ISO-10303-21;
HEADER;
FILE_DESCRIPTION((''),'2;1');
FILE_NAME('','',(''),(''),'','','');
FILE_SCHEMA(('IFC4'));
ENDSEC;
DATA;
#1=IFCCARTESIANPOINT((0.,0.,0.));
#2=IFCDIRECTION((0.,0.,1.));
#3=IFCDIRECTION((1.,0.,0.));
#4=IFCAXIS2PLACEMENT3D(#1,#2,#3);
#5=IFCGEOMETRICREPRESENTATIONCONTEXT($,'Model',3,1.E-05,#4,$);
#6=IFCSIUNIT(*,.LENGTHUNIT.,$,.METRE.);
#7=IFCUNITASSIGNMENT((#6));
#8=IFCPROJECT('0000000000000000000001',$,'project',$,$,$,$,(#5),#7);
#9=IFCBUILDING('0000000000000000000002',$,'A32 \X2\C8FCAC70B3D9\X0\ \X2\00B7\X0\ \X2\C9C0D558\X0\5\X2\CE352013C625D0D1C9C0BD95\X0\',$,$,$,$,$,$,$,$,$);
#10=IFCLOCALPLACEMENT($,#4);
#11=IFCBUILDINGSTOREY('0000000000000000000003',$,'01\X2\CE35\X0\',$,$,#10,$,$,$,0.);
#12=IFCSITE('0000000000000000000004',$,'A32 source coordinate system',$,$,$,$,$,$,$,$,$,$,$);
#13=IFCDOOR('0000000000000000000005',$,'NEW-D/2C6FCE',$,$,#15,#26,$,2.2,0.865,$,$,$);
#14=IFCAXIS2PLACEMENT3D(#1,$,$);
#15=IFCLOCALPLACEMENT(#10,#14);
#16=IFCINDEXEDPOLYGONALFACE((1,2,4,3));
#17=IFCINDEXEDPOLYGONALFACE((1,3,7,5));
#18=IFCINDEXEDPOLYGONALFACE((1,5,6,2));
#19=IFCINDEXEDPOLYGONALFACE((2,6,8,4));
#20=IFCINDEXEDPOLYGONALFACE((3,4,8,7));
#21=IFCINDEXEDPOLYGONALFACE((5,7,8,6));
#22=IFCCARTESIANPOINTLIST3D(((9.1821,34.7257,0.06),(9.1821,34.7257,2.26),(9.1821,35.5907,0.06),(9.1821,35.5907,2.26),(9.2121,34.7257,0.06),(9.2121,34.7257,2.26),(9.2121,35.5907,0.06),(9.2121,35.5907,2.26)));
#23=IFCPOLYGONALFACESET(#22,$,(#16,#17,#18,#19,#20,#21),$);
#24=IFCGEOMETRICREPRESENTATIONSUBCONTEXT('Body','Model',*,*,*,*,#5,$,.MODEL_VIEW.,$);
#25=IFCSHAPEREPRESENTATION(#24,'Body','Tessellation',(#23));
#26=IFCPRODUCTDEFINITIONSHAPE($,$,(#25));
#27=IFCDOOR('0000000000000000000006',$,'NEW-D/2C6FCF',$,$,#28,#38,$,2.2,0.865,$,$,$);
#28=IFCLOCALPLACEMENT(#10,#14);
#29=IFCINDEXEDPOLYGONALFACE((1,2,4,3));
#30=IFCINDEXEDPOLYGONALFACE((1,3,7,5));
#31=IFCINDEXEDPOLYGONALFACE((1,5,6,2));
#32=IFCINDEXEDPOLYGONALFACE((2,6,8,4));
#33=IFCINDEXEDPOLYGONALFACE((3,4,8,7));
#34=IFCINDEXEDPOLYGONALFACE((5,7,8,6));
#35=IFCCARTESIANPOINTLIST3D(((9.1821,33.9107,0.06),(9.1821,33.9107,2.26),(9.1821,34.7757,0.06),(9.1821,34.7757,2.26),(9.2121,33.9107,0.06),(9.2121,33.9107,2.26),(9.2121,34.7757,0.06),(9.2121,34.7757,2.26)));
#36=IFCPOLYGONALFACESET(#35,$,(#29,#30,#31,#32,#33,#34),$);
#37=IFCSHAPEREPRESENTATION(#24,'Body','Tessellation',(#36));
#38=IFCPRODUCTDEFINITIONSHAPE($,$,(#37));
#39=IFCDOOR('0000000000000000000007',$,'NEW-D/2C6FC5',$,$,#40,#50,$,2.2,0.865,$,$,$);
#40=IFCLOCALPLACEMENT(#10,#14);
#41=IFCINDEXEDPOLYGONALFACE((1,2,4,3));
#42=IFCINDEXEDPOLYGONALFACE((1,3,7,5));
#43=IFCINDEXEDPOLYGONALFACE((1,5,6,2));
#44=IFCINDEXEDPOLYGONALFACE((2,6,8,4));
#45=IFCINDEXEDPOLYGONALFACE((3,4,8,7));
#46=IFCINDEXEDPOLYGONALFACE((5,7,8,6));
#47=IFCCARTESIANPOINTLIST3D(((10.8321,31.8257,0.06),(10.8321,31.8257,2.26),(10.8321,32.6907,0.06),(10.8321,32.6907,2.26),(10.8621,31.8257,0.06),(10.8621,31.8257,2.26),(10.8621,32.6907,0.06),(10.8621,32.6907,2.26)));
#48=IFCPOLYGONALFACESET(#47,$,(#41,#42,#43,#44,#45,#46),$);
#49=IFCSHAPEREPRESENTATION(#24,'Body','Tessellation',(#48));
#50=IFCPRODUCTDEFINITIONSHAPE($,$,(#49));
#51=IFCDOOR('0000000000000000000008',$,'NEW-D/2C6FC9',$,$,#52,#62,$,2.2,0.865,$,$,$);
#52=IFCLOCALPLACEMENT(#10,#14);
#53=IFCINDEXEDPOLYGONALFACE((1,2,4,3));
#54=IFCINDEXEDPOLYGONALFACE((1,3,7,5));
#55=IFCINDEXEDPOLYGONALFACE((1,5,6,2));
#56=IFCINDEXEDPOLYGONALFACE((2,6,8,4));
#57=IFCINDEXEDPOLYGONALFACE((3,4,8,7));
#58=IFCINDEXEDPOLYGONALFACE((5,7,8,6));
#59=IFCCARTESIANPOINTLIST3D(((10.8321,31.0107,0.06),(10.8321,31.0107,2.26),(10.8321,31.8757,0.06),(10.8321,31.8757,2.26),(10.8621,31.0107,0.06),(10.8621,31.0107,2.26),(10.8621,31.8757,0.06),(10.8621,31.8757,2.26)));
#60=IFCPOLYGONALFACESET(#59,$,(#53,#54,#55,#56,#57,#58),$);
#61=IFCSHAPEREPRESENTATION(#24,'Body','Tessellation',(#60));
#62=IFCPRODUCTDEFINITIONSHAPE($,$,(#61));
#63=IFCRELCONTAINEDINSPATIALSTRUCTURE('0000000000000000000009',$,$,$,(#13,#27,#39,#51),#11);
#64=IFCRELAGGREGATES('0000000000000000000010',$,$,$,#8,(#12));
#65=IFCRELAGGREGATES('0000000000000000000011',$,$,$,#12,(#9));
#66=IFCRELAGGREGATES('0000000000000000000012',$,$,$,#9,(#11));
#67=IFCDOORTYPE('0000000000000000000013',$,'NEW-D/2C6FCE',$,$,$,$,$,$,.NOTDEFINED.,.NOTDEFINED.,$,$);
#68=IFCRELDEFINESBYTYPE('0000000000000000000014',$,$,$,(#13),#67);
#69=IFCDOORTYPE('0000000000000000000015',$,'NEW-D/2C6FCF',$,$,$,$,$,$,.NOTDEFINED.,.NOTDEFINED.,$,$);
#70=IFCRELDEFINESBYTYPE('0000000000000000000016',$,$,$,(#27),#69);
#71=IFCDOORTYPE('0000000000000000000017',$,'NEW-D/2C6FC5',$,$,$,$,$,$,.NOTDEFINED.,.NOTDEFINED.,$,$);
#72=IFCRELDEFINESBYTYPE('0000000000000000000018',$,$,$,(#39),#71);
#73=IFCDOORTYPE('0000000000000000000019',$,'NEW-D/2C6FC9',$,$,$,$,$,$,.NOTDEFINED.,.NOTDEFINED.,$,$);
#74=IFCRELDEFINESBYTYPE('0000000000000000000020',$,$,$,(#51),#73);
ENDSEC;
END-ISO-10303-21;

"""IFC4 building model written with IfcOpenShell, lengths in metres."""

from ifc_helpers import new_model, si_unit, frame, origin, origin_with_axes, place, context, subcontext, project, spatial, polyline, outline, extrude, source, transform, mapped, type_object, type_shapes, element, save


model = new_model("IFC4")

# Units and contexts
model_context = context("Model", 3, precision=1e-05, world=origin_with_axes())
body_context = subcontext(model_context, "Body", "Model", "MODEL_VIEW")
ifc_project = project(units=[si_unit("LENGTHUNIT", "METRE")], contexts=[model_context])

# Site, building, storey
storey_placement = place(None, origin_with_axes())
site = spatial("IfcSite", under=ifc_project, Name="A32 source coordinate system")
building = spatial("IfcBuilding", under=site, Name="A32 주거동 · 지하5층–옥탑지붕")
storey = spatial("IfcBuildingStorey", under=building, at=storey_placement, Name="01층", Elevation=0.0)

# Doors
door_type_1 = type_object("IfcDoorType", Name="NEW-D/2C6FCE", OperationType="NOTDEFINED", PredefinedType="NOTDEFINED")
shared_shape_1 = source(origin(), body_context, "Body", "SweptSolid", [
    extrude(outline(polyline([(9.1821, 35.5907), (9.2121, 35.5907), (9.2121, 34.7257), (9.1821, 34.7257), (9.1821, 35.5907)])), frame((0.0, 0.0, 0.06)), (0.0, 0.0, 1.0), 2.2),
])
type_shapes(door_type_1, [shared_shape_1])
door_1_placement = place(storey_placement, origin_with_axes())
element("IfcDoor", 1, at=door_1_placement, inside=storey, type_object=door_type_1, Name="NEW-D/2C6FCE", OverallHeight=2.2, OverallWidth=0.865, context=body_context, shape_type="MappedRepresentation", body=[
    mapped(shared_shape_1, transform((0.0, 0.0, 0.0), scale=1.0)),
])
door_type_2 = type_object("IfcDoorType", Name="NEW-D/2C6FCF", OperationType="NOTDEFINED", PredefinedType="NOTDEFINED")
shared_shape_2 = source(origin(), body_context, "Body", "SweptSolid", [
    extrude(outline(polyline([(9.2121, 34.7757), (9.2121, 33.9107), (9.1821, 33.9107), (9.1821, 34.7757), (9.2121, 34.7757)])), frame((0.0, 0.0, 0.06)), (0.0, 0.0, 1.0), 2.2),
])
type_shapes(door_type_2, [shared_shape_2])
door_2_placement = place(storey_placement, origin_with_axes())
element("IfcDoor", 2, at=door_2_placement, inside=storey, type_object=door_type_2, Name="NEW-D/2C6FCF", OverallHeight=2.2, OverallWidth=0.865, context=body_context, shape_type="MappedRepresentation", body=[
    mapped(shared_shape_2, transform((0.0, 0.0, 0.0), scale=1.0)),
])
door_type_3 = type_object("IfcDoorType", Name="NEW-D/2C6FC5", OperationType="NOTDEFINED", PredefinedType="NOTDEFINED")
shared_shape_3 = source(origin(), body_context, "Body", "SweptSolid", [
    extrude(outline(polyline([(10.8321, 31.8257), (10.8321, 32.6907), (10.8621, 32.6907), (10.8621, 31.8257), (10.8321, 31.8257)])), frame((0.0, 0.0, 0.06)), (0.0, 0.0, 1.0), 2.2),
])
type_shapes(door_type_3, [shared_shape_3])
door_3_placement = place(storey_placement, origin_with_axes())
element("IfcDoor", 3, at=door_3_placement, inside=storey, type_object=door_type_3, Name="NEW-D/2C6FC5", OverallHeight=2.2, OverallWidth=0.865, context=body_context, shape_type="MappedRepresentation", body=[
    mapped(shared_shape_3, transform((0.0, 0.0, 0.0), scale=1.0)),
])
door_type_4 = type_object("IfcDoorType", Name="NEW-D/2C6FC9", OperationType="NOTDEFINED", PredefinedType="NOTDEFINED")
shared_shape_4 = source(origin(), body_context, "Body", "SweptSolid", [
    extrude(outline(polyline([(10.8621, 31.0107), (10.8321, 31.0107), (10.8321, 31.8757), (10.8621, 31.8757), (10.8621, 31.0107)])), frame((0.0, 0.0, 0.06)), (0.0, 0.0, 1.0), 2.2),
])
type_shapes(door_type_4, [shared_shape_4])
door_4_placement = place(storey_placement, origin_with_axes())
element("IfcDoor", 4, at=door_4_placement, inside=storey, type_object=door_type_4, Name="NEW-D/2C6FC9", OverallHeight=2.2, OverallWidth=0.865, context=body_context, shape_type="MappedRepresentation", body=[
    mapped(shared_shape_4, transform((0.0, 0.0, 0.0), scale=1.0)),
])

save(model, "model.ifc")
